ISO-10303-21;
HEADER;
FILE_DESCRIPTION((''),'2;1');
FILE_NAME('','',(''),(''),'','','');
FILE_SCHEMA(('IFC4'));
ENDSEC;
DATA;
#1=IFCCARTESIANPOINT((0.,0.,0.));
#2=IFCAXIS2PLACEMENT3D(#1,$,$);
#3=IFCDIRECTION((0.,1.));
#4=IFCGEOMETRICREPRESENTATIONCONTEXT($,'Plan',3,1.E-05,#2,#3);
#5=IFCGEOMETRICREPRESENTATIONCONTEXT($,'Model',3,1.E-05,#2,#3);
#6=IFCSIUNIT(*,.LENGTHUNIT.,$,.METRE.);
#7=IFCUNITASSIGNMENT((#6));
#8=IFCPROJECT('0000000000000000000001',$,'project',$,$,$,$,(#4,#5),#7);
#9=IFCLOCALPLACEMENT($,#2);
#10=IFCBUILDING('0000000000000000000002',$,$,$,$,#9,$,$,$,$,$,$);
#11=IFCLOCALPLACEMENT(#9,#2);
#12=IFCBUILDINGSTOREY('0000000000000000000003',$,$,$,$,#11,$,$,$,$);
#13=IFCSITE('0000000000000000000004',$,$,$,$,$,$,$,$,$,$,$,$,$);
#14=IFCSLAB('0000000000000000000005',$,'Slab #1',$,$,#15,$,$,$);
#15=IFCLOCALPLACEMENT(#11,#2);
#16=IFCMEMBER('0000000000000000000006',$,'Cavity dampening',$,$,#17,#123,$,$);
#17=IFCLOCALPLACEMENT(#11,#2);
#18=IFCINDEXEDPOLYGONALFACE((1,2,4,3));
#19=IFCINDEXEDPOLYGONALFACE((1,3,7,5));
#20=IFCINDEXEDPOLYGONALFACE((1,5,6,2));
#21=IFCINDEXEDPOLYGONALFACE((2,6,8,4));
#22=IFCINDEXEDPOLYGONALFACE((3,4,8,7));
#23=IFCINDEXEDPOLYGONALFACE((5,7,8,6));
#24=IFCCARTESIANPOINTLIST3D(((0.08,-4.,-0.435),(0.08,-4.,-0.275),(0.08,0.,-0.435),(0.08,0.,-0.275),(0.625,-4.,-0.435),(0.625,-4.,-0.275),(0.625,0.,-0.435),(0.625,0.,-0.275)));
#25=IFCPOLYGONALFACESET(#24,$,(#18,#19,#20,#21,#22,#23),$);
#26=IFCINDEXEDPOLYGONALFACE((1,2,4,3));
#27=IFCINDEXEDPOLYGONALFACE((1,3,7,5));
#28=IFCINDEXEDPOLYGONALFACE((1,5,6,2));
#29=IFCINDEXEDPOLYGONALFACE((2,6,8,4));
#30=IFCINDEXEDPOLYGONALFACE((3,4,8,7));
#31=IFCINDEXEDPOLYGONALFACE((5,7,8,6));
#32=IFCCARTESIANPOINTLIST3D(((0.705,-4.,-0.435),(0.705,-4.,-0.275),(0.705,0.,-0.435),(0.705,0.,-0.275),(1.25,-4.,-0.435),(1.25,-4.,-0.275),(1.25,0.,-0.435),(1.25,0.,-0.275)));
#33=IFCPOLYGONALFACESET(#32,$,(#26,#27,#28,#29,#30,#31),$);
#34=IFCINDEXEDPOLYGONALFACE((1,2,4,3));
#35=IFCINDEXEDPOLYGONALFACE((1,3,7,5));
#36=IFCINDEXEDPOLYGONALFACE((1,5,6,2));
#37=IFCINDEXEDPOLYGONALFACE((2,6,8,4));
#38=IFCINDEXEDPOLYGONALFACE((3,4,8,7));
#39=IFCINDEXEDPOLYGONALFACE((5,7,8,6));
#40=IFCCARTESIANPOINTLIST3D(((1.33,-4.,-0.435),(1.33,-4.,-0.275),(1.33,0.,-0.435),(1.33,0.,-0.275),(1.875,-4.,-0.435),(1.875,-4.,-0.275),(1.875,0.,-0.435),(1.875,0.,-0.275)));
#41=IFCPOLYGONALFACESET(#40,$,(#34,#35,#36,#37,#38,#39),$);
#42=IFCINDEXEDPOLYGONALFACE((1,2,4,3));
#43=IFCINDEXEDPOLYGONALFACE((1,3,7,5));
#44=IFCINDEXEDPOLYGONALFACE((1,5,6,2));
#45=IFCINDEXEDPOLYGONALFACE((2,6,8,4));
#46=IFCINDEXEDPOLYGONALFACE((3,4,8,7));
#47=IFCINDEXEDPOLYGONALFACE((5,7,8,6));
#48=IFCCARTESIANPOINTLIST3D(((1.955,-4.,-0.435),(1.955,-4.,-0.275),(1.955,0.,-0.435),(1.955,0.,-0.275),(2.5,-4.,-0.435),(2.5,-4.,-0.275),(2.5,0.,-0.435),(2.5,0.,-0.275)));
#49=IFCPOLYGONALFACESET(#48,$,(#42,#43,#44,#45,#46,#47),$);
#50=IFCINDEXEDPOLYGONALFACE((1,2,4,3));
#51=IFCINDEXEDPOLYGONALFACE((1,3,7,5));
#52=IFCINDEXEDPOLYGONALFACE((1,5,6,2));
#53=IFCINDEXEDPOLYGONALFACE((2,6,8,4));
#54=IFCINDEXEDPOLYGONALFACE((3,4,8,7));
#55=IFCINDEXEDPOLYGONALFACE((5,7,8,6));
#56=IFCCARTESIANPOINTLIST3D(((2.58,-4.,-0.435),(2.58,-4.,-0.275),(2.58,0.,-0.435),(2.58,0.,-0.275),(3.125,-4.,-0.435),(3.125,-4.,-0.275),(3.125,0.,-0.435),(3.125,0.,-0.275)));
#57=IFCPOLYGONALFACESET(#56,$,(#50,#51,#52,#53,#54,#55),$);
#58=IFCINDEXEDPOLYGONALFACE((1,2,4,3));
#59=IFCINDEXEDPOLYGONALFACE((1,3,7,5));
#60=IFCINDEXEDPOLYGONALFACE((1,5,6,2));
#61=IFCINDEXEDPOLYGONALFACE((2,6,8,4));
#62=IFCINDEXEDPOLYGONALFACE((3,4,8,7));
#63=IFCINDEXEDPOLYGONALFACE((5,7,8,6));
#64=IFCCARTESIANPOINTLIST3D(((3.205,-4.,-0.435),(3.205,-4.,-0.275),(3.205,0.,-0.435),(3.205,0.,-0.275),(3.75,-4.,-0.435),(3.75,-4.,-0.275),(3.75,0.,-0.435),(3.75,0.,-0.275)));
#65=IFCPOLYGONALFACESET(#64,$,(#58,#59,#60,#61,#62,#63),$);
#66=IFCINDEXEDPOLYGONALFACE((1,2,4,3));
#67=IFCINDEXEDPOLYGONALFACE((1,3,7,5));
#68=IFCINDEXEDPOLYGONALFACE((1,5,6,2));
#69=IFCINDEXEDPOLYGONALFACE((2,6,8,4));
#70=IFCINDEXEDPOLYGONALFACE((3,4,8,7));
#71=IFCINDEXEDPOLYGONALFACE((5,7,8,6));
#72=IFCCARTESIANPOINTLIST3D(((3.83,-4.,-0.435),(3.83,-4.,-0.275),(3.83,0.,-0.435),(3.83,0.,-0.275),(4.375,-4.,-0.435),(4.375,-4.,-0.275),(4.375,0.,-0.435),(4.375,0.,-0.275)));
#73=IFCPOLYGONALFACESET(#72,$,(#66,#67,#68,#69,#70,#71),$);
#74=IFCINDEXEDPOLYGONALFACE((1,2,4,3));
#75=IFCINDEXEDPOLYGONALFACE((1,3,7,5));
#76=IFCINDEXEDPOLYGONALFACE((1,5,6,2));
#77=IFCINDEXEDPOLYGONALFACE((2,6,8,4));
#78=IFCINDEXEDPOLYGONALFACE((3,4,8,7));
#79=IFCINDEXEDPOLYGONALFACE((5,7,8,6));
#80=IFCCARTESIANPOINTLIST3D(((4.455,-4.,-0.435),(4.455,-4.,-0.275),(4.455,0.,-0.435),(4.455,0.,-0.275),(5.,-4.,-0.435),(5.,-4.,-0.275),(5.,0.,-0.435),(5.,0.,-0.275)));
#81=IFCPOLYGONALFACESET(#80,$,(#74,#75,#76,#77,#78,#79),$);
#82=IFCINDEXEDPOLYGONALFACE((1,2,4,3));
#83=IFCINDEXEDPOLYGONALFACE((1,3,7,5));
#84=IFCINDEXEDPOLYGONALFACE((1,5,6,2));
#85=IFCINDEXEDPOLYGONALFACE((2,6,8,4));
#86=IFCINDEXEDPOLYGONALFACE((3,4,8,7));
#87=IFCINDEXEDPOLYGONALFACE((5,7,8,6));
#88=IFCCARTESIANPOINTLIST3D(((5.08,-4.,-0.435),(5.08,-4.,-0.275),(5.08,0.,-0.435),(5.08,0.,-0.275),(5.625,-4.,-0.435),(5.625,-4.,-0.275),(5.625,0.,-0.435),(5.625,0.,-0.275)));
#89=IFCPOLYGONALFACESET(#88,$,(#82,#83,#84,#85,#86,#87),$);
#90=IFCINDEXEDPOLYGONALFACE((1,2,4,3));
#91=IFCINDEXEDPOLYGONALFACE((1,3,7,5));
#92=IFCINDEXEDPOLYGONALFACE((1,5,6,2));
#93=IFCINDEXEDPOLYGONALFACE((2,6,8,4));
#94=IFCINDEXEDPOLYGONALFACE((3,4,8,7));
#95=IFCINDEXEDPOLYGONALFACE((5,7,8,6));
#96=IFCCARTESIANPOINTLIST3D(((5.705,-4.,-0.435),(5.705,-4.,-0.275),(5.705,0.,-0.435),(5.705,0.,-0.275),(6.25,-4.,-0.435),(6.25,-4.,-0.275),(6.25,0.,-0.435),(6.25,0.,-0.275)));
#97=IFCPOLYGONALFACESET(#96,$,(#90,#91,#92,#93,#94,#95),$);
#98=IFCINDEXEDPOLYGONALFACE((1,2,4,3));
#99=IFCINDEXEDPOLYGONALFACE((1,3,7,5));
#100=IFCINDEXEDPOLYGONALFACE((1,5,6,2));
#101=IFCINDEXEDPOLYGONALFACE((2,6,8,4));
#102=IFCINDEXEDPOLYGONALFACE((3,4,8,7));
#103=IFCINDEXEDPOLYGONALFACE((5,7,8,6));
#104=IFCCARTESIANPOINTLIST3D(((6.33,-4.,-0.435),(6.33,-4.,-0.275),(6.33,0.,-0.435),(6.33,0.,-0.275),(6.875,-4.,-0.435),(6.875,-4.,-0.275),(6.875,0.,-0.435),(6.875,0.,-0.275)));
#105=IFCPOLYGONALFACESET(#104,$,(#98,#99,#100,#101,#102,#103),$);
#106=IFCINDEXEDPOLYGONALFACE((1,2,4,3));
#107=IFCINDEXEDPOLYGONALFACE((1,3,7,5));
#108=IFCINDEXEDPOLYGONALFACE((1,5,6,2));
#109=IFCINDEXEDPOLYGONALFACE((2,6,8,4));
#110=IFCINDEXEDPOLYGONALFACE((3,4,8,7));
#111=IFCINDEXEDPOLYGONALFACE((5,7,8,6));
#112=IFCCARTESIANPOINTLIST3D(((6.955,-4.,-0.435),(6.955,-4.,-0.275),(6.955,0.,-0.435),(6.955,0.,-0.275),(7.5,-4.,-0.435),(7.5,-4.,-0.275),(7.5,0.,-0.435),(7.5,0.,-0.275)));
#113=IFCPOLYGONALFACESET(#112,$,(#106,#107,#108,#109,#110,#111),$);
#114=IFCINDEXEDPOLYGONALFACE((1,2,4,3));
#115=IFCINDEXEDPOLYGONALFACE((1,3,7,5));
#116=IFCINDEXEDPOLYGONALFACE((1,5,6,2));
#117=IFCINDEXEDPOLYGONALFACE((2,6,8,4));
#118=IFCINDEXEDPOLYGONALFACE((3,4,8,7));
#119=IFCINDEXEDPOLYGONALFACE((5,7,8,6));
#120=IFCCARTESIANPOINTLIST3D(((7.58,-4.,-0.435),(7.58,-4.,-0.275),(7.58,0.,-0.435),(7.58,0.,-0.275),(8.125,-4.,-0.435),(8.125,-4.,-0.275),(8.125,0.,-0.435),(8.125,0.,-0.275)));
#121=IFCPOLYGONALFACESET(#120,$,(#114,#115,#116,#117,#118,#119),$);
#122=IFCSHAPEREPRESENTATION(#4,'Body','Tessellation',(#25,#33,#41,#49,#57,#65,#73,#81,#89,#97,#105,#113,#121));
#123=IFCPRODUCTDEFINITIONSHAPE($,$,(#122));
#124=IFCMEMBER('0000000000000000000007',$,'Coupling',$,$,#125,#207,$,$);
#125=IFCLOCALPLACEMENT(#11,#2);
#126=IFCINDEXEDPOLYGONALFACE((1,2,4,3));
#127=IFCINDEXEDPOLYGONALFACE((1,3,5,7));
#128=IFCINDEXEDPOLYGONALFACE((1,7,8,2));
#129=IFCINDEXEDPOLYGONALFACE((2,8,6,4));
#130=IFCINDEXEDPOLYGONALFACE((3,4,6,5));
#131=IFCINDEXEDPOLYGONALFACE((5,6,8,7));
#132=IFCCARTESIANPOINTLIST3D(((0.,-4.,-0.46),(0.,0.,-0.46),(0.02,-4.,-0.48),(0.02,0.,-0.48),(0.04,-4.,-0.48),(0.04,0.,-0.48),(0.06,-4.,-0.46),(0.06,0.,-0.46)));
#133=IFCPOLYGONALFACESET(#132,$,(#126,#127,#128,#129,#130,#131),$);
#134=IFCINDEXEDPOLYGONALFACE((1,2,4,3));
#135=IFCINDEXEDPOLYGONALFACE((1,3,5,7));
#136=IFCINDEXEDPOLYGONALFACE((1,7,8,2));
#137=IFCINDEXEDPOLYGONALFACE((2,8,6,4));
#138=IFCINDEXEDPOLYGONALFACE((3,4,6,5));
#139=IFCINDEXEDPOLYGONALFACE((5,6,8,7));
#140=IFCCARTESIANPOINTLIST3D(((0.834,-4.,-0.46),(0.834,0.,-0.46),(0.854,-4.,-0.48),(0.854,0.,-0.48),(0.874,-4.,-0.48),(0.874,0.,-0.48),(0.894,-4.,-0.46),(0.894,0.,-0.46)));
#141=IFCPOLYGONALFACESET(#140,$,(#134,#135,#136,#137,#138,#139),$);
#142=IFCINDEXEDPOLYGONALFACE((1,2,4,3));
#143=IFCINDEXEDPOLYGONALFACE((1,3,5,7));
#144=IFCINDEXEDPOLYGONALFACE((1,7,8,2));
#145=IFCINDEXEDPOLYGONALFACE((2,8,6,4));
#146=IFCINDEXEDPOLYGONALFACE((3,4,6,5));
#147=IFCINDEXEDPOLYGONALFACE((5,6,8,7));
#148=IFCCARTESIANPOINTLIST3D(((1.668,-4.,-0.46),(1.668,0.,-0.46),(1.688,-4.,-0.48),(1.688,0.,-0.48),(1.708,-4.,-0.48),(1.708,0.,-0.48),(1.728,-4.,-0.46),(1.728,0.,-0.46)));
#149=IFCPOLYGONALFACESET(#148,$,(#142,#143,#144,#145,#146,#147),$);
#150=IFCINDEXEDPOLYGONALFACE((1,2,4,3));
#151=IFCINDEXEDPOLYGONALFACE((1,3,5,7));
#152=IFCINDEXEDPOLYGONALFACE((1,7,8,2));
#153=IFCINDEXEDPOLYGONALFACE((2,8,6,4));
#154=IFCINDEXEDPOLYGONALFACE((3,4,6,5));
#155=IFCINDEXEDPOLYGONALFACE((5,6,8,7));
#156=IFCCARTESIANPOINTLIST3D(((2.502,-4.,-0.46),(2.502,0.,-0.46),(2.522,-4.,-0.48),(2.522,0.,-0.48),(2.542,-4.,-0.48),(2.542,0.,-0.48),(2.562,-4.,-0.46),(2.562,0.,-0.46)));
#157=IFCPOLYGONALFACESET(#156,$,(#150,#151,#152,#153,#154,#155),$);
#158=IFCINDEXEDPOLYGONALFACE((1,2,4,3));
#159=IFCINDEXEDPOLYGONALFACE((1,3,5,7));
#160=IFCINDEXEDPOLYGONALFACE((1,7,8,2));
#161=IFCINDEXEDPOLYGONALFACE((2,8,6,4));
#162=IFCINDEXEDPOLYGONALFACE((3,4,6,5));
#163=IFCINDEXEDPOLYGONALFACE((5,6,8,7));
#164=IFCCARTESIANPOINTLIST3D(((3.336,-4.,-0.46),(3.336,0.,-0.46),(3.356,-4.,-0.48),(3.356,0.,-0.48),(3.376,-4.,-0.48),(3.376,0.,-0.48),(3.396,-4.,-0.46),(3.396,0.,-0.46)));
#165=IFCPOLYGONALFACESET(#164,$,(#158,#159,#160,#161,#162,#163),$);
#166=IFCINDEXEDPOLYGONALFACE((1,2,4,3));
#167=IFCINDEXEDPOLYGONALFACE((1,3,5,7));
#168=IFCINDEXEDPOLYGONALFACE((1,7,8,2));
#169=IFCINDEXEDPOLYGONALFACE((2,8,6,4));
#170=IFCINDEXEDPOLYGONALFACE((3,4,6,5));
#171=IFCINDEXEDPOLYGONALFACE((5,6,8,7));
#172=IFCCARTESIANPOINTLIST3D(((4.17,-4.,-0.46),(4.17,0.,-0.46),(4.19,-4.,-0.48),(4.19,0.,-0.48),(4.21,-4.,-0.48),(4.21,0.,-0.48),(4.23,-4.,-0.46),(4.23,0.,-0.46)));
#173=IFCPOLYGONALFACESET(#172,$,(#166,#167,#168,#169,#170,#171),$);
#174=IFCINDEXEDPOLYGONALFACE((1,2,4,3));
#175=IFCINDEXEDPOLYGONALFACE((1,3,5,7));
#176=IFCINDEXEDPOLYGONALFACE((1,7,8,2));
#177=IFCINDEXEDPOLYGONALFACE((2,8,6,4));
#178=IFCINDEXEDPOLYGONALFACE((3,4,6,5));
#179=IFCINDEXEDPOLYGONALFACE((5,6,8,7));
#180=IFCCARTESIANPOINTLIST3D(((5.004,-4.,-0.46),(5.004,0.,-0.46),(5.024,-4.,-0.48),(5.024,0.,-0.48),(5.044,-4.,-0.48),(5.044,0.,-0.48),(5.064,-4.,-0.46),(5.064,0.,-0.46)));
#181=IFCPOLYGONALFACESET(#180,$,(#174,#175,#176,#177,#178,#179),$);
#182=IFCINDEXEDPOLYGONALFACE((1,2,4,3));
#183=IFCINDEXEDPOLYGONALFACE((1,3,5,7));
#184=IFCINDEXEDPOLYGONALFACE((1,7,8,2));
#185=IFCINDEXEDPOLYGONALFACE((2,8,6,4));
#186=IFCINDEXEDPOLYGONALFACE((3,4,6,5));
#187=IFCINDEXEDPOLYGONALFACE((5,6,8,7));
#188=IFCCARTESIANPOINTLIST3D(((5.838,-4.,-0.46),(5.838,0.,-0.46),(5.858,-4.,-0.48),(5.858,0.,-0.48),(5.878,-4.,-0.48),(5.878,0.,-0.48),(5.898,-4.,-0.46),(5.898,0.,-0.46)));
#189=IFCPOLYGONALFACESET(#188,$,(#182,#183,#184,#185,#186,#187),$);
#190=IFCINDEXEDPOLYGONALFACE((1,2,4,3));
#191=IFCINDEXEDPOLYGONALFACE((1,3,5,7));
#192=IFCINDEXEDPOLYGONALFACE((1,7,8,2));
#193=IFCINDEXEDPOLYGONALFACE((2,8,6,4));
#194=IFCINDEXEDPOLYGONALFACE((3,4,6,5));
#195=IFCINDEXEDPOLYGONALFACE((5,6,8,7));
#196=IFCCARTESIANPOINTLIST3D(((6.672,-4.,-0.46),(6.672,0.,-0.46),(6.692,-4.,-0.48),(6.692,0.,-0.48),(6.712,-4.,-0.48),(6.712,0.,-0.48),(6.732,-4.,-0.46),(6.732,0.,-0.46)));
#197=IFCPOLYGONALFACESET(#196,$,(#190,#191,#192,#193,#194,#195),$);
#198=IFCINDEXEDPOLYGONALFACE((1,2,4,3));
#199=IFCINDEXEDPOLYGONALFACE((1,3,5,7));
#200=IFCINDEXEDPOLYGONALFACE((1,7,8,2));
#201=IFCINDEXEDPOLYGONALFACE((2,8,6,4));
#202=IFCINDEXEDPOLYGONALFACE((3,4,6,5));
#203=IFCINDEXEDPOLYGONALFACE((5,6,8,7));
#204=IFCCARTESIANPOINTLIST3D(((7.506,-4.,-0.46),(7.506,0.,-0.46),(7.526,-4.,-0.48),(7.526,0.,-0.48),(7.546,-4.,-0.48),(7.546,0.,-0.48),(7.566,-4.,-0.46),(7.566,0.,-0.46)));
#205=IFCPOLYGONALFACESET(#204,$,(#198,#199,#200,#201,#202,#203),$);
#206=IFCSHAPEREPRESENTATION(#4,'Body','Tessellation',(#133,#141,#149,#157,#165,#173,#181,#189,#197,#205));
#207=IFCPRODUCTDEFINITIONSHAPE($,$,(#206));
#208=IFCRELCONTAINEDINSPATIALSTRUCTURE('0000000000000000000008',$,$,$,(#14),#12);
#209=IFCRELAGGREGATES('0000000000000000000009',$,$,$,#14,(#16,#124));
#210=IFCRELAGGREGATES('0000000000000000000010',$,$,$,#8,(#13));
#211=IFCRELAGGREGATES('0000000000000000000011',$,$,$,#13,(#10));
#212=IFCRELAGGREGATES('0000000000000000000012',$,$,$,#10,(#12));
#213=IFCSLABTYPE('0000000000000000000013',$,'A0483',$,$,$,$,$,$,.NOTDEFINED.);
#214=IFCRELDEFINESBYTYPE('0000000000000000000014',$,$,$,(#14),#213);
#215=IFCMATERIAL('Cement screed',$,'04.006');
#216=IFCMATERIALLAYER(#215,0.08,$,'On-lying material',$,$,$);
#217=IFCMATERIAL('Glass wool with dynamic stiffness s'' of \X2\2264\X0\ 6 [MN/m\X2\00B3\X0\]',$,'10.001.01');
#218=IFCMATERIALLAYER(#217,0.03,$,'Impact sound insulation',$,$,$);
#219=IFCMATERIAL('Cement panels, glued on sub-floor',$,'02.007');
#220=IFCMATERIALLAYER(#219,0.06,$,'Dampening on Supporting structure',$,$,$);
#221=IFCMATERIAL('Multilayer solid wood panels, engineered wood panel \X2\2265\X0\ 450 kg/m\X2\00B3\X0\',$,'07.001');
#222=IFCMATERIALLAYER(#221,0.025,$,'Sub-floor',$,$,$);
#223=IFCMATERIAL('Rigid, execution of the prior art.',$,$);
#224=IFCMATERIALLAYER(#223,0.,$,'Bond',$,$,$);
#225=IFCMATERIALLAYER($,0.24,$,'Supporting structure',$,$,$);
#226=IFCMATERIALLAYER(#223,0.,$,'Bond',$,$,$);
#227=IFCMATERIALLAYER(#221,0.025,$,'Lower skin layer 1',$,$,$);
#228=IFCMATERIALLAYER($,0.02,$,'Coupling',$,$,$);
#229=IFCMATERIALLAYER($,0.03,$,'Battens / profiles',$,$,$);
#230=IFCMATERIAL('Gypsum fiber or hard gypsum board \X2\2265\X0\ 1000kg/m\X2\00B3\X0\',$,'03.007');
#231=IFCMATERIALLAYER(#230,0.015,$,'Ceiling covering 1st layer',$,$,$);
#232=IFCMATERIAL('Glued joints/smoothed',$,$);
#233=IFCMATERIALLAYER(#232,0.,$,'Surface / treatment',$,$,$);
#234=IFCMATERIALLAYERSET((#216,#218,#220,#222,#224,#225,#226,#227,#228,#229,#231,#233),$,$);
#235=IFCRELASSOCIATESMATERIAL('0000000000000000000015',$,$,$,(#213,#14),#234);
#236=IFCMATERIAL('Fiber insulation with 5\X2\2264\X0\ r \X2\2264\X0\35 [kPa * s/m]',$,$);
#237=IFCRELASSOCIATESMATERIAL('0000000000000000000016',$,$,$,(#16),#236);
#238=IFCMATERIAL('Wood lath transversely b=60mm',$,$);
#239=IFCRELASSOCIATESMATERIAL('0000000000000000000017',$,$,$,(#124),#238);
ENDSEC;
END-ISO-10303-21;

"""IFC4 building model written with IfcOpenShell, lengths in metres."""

from ifc_helpers import new_model, si_unit, direction, frame, frame_2d, origin, place, context, project, spatial, polyline, rectangle, outline, extrude, material, layer, layer_set, type_object, element, aggregate, save


model = new_model("IFC4")

# Units and contexts
plan_context = context("Plan", 3, precision=1e-05, world=origin(), true_north=direction((0.0, 1.0)))
model_context = context("Model", 3, precision=1e-05, world=origin(), true_north=direction((0.0, 1.0)))
ifc_project = project(units=[si_unit("LENGTHUNIT", "METRE")], contexts=[plan_context, model_context])

# Site, building, storey
site = spatial("IfcSite", under=ifc_project)
building_placement = place(None, origin())
building = spatial("IfcBuilding", under=site, at=building_placement)
storey_placement = place(building_placement, origin())
storey = spatial("IfcBuildingStorey", under=building, at=storey_placement)

# Slab, members
ifc_material_1 = material(Name="Cement screed", Category="04.006")
ifc_layer_1 = layer(ifc_material_1, 0.08, Name="On-lying material")
ifc_material_2 = material(Name="Glass wool with dynamic stiffness s' of ≤ 6 [MN/m³]", Category="10.001.01")
ifc_layer_2 = layer(ifc_material_2, 0.03, Name="Impact sound insulation")
ifc_material_3 = material(Name="Cement panels, glued on sub-floor", Category="02.007")
ifc_layer_3 = layer(ifc_material_3, 0.06, Name="Dampening on Supporting structure")
ifc_material_4 = material(Name="Multilayer solid wood panels, engineered wood panel ≥ 450 kg/m³", Category="07.001")
ifc_layer_4 = layer(ifc_material_4, 0.025, Name="Sub-floor")
ifc_material_5 = material(Name="Rigid, execution of the prior art.")
ifc_layer_5 = layer(ifc_material_5, 0.0, Name="Bond")
ifc_layer_6 = layer(None, 0.24, Name="Supporting structure")
ifc_layer_7 = layer(ifc_material_5, 0.0, Name="Bond")
ifc_layer_8 = layer(ifc_material_4, 0.025, Name="Lower skin layer 1")
ifc_layer_9 = layer(None, 0.02, Name="Coupling")
ifc_layer_10 = layer(None, 0.03, Name="Battens / profiles")
ifc_material_6 = material(Name="Gypsum fiber or hard gypsum board ≥ 1000kg/m³", Category="03.007")
ifc_layer_11 = layer(ifc_material_6, 0.015, Name="Ceiling covering 1st layer")
ifc_material_7 = material(Name="Glued joints/smoothed")
ifc_layer_12 = layer(ifc_material_7, 0.0, Name="Surface / treatment")
ifc_layer_set = layer_set([ifc_layer_1, ifc_layer_2, ifc_layer_3, ifc_layer_4, ifc_layer_5, ifc_layer_6, ifc_layer_7, ifc_layer_8, ifc_layer_9, ifc_layer_10, ifc_layer_11, ifc_layer_12])
slab_type = type_object("IfcSlabType", Name="A0483", PredefinedType="NOTDEFINED", material=ifc_layer_set)
slab_placement = place(None, frame((0.0, 0.0, 0.0), z_axis=(0.0, 0.0, -1.0), x_axis=(1.0, 0.0, 0.0)))
slab = element("IfcSlab", 1, at=slab_placement, inside=storey, type_object=slab_type, material=ifc_layer_set, Name="Slab #1")
ifc_material_8 = material(Name="Fiber insulation with 5≤ r ≤35 [kPa * s/m]")
member_1_placement = place(slab_placement, origin())
member_1 = element("IfcMember", 2, at=member_1_placement, material=ifc_material_8, Name="Cavity dampening", context=plan_context, shape_type="SweptSolid", body=[
    extrude(rectangle(XDim=0.545, YDim=0.16, at=frame_2d((0.2725, 0.08), x_axis=(1.0, 0.0))), frame((0.08, 4.0, 0.275), z_axis=(0.0, -1.0, 0.0), x_axis=(1.0, 0.0, 0.0)), (0.0, 0.0, 1.0), 4.0),
    extrude(rectangle(XDim=0.545, YDim=0.16, at=frame_2d((0.2725, 0.08), x_axis=(1.0, 0.0))), frame((0.705, 4.0, 0.275), z_axis=(0.0, -1.0, 0.0), x_axis=(1.0, 0.0, 0.0)), (0.0, 0.0, 1.0), 4.0),
    extrude(rectangle(XDim=0.545, YDim=0.16, at=frame_2d((0.2725, 0.08), x_axis=(1.0, 0.0))), frame((1.33, 4.0, 0.275), z_axis=(0.0, -1.0, 0.0), x_axis=(1.0, 0.0, 0.0)), (0.0, 0.0, 1.0), 4.0),
    extrude(rectangle(XDim=0.545, YDim=0.16, at=frame_2d((0.2725, 0.08), x_axis=(1.0, 0.0))), frame((1.955, 4.0, 0.275), z_axis=(0.0, -1.0, 0.0), x_axis=(1.0, 0.0, 0.0)), (0.0, 0.0, 1.0), 4.0),
    extrude(rectangle(XDim=0.545, YDim=0.16, at=frame_2d((0.2725, 0.08), x_axis=(1.0, 0.0))), frame((2.58, 4.0, 0.275), z_axis=(0.0, -1.0, 0.0), x_axis=(1.0, 0.0, 0.0)), (0.0, 0.0, 1.0), 4.0),
    extrude(rectangle(XDim=0.545, YDim=0.16, at=frame_2d((0.2725, 0.08), x_axis=(1.0, 0.0))), frame((3.205, 4.0, 0.275), z_axis=(0.0, -1.0, 0.0), x_axis=(1.0, 0.0, 0.0)), (0.0, 0.0, 1.0), 4.0),
    extrude(rectangle(XDim=0.545, YDim=0.16, at=frame_2d((0.2725, 0.08), x_axis=(1.0, 0.0))), frame((3.83, 4.0, 0.275), z_axis=(0.0, -1.0, 0.0), x_axis=(1.0, 0.0, 0.0)), (0.0, 0.0, 1.0), 4.0),
    extrude(rectangle(XDim=0.545, YDim=0.16, at=frame_2d((0.2725, 0.08), x_axis=(1.0, 0.0))), frame((4.455, 4.0, 0.275), z_axis=(0.0, -1.0, 0.0), x_axis=(1.0, 0.0, 0.0)), (0.0, 0.0, 1.0), 4.0),
    extrude(rectangle(XDim=0.545, YDim=0.16, at=frame_2d((0.2725, 0.08), x_axis=(1.0, 0.0))), frame((5.08, 4.0, 0.275), z_axis=(0.0, -1.0, 0.0), x_axis=(1.0, 0.0, 0.0)), (0.0, 0.0, 1.0), 4.0),
    extrude(rectangle(XDim=0.545, YDim=0.16, at=frame_2d((0.2725, 0.08), x_axis=(1.0, 0.0))), frame((5.705, 4.0, 0.275), z_axis=(0.0, -1.0, 0.0), x_axis=(1.0, 0.0, 0.0)), (0.0, 0.0, 1.0), 4.0),
    extrude(rectangle(XDim=0.545, YDim=0.16, at=frame_2d((0.2725, 0.08), x_axis=(1.0, 0.0))), frame((6.33, 4.0, 0.275), z_axis=(0.0, -1.0, 0.0), x_axis=(1.0, 0.0, 0.0)), (0.0, 0.0, 1.0), 4.0),
    extrude(rectangle(XDim=0.545, YDim=0.16, at=frame_2d((0.2725, 0.08), x_axis=(1.0, 0.0))), frame((6.955, 4.0, 0.275), z_axis=(0.0, -1.0, 0.0), x_axis=(1.0, 0.0, 0.0)), (0.0, 0.0, 1.0), 4.0),
    extrude(rectangle(XDim=0.545, YDim=0.16, at=frame_2d((0.2725, 0.08), x_axis=(1.0, 0.0))), frame((7.58, 4.0, 0.275), z_axis=(0.0, -1.0, 0.0), x_axis=(1.0, 0.0, 0.0)), (0.0, 0.0, 1.0), 4.0),
])
ifc_material_9 = material(Name="Wood lath transversely b=60mm")
member_2_placement = place(slab_placement, origin())
member_2 = element("IfcMember", 3, at=member_2_placement, material=ifc_material_9, Name="Coupling", context=plan_context, shape_type="SweptSolid", body=[
    extrude(outline(polyline([(0.0, 0.0), (0.06, 0.0), (0.04, 0.02), (0.02, 0.02), (0.0, 0.0)])), frame((0.0, 4.0, 0.46), z_axis=(0.0, -1.0, 0.0), x_axis=(1.0, 0.0, 0.0)), (0.0, 0.0, 1.0), 4.0),
    extrude(outline(polyline([(0.0, 0.0), (0.06, 0.0), (0.04, 0.02), (0.02, 0.02), (0.0, 0.0)])), frame((0.834, 4.0, 0.46), z_axis=(0.0, -1.0, 0.0), x_axis=(1.0, 0.0, 0.0)), (0.0, 0.0, 1.0), 4.0),
    extrude(outline(polyline([(0.0, 0.0), (0.06, 0.0), (0.04, 0.02), (0.02, 0.02), (0.0, 0.0)])), frame((1.668, 4.0, 0.46), z_axis=(0.0, -1.0, 0.0), x_axis=(1.0, 0.0, 0.0)), (0.0, 0.0, 1.0), 4.0),
    extrude(outline(polyline([(0.0, 0.0), (0.06, 0.0), (0.04, 0.02), (0.02, 0.02), (0.0, 0.0)])), frame((2.502, 4.0, 0.46), z_axis=(0.0, -1.0, 0.0), x_axis=(1.0, 0.0, 0.0)), (0.0, 0.0, 1.0), 4.0),
    extrude(outline(polyline([(0.0, 0.0), (0.06, 0.0), (0.04, 0.02), (0.02, 0.02), (0.0, 0.0)])), frame((3.336, 4.0, 0.46), z_axis=(0.0, -1.0, 0.0), x_axis=(1.0, 0.0, 0.0)), (0.0, 0.0, 1.0), 4.0),
    extrude(outline(polyline([(0.0, 0.0), (0.06, 0.0), (0.04, 0.02), (0.02, 0.02), (0.0, 0.0)])), frame((4.17, 4.0, 0.46), z_axis=(0.0, -1.0, 0.0), x_axis=(1.0, 0.0, 0.0)), (0.0, 0.0, 1.0), 4.0),
    extrude(outline(polyline([(0.0, 0.0), (0.06, 0.0), (0.04, 0.02), (0.02, 0.02), (0.0, 0.0)])), frame((5.004, 4.0, 0.46), z_axis=(0.0, -1.0, 0.0), x_axis=(1.0, 0.0, 0.0)), (0.0, 0.0, 1.0), 4.0),
    extrude(outline(polyline([(0.0, 0.0), (0.06, 0.0), (0.04, 0.02), (0.02, 0.02), (0.0, 0.0)])), frame((5.838, 4.0, 0.46), z_axis=(0.0, -1.0, 0.0), x_axis=(1.0, 0.0, 0.0)), (0.0, 0.0, 1.0), 4.0),
    extrude(outline(polyline([(0.0, 0.0), (0.06, 0.0), (0.04, 0.02), (0.02, 0.02), (0.0, 0.0)])), frame((6.672, 4.0, 0.46), z_axis=(0.0, -1.0, 0.0), x_axis=(1.0, 0.0, 0.0)), (0.0, 0.0, 1.0), 4.0),
    extrude(outline(polyline([(0.0, 0.0), (0.06, 0.0), (0.04, 0.02), (0.02, 0.02), (0.0, 0.0)])), frame((7.506, 4.0, 0.46), z_axis=(0.0, -1.0, 0.0), x_axis=(1.0, 0.0, 0.0)), (0.0, 0.0, 1.0), 4.0),
])
aggregate(slab, [member_1, member_2])

save(model, "model.ifc")
